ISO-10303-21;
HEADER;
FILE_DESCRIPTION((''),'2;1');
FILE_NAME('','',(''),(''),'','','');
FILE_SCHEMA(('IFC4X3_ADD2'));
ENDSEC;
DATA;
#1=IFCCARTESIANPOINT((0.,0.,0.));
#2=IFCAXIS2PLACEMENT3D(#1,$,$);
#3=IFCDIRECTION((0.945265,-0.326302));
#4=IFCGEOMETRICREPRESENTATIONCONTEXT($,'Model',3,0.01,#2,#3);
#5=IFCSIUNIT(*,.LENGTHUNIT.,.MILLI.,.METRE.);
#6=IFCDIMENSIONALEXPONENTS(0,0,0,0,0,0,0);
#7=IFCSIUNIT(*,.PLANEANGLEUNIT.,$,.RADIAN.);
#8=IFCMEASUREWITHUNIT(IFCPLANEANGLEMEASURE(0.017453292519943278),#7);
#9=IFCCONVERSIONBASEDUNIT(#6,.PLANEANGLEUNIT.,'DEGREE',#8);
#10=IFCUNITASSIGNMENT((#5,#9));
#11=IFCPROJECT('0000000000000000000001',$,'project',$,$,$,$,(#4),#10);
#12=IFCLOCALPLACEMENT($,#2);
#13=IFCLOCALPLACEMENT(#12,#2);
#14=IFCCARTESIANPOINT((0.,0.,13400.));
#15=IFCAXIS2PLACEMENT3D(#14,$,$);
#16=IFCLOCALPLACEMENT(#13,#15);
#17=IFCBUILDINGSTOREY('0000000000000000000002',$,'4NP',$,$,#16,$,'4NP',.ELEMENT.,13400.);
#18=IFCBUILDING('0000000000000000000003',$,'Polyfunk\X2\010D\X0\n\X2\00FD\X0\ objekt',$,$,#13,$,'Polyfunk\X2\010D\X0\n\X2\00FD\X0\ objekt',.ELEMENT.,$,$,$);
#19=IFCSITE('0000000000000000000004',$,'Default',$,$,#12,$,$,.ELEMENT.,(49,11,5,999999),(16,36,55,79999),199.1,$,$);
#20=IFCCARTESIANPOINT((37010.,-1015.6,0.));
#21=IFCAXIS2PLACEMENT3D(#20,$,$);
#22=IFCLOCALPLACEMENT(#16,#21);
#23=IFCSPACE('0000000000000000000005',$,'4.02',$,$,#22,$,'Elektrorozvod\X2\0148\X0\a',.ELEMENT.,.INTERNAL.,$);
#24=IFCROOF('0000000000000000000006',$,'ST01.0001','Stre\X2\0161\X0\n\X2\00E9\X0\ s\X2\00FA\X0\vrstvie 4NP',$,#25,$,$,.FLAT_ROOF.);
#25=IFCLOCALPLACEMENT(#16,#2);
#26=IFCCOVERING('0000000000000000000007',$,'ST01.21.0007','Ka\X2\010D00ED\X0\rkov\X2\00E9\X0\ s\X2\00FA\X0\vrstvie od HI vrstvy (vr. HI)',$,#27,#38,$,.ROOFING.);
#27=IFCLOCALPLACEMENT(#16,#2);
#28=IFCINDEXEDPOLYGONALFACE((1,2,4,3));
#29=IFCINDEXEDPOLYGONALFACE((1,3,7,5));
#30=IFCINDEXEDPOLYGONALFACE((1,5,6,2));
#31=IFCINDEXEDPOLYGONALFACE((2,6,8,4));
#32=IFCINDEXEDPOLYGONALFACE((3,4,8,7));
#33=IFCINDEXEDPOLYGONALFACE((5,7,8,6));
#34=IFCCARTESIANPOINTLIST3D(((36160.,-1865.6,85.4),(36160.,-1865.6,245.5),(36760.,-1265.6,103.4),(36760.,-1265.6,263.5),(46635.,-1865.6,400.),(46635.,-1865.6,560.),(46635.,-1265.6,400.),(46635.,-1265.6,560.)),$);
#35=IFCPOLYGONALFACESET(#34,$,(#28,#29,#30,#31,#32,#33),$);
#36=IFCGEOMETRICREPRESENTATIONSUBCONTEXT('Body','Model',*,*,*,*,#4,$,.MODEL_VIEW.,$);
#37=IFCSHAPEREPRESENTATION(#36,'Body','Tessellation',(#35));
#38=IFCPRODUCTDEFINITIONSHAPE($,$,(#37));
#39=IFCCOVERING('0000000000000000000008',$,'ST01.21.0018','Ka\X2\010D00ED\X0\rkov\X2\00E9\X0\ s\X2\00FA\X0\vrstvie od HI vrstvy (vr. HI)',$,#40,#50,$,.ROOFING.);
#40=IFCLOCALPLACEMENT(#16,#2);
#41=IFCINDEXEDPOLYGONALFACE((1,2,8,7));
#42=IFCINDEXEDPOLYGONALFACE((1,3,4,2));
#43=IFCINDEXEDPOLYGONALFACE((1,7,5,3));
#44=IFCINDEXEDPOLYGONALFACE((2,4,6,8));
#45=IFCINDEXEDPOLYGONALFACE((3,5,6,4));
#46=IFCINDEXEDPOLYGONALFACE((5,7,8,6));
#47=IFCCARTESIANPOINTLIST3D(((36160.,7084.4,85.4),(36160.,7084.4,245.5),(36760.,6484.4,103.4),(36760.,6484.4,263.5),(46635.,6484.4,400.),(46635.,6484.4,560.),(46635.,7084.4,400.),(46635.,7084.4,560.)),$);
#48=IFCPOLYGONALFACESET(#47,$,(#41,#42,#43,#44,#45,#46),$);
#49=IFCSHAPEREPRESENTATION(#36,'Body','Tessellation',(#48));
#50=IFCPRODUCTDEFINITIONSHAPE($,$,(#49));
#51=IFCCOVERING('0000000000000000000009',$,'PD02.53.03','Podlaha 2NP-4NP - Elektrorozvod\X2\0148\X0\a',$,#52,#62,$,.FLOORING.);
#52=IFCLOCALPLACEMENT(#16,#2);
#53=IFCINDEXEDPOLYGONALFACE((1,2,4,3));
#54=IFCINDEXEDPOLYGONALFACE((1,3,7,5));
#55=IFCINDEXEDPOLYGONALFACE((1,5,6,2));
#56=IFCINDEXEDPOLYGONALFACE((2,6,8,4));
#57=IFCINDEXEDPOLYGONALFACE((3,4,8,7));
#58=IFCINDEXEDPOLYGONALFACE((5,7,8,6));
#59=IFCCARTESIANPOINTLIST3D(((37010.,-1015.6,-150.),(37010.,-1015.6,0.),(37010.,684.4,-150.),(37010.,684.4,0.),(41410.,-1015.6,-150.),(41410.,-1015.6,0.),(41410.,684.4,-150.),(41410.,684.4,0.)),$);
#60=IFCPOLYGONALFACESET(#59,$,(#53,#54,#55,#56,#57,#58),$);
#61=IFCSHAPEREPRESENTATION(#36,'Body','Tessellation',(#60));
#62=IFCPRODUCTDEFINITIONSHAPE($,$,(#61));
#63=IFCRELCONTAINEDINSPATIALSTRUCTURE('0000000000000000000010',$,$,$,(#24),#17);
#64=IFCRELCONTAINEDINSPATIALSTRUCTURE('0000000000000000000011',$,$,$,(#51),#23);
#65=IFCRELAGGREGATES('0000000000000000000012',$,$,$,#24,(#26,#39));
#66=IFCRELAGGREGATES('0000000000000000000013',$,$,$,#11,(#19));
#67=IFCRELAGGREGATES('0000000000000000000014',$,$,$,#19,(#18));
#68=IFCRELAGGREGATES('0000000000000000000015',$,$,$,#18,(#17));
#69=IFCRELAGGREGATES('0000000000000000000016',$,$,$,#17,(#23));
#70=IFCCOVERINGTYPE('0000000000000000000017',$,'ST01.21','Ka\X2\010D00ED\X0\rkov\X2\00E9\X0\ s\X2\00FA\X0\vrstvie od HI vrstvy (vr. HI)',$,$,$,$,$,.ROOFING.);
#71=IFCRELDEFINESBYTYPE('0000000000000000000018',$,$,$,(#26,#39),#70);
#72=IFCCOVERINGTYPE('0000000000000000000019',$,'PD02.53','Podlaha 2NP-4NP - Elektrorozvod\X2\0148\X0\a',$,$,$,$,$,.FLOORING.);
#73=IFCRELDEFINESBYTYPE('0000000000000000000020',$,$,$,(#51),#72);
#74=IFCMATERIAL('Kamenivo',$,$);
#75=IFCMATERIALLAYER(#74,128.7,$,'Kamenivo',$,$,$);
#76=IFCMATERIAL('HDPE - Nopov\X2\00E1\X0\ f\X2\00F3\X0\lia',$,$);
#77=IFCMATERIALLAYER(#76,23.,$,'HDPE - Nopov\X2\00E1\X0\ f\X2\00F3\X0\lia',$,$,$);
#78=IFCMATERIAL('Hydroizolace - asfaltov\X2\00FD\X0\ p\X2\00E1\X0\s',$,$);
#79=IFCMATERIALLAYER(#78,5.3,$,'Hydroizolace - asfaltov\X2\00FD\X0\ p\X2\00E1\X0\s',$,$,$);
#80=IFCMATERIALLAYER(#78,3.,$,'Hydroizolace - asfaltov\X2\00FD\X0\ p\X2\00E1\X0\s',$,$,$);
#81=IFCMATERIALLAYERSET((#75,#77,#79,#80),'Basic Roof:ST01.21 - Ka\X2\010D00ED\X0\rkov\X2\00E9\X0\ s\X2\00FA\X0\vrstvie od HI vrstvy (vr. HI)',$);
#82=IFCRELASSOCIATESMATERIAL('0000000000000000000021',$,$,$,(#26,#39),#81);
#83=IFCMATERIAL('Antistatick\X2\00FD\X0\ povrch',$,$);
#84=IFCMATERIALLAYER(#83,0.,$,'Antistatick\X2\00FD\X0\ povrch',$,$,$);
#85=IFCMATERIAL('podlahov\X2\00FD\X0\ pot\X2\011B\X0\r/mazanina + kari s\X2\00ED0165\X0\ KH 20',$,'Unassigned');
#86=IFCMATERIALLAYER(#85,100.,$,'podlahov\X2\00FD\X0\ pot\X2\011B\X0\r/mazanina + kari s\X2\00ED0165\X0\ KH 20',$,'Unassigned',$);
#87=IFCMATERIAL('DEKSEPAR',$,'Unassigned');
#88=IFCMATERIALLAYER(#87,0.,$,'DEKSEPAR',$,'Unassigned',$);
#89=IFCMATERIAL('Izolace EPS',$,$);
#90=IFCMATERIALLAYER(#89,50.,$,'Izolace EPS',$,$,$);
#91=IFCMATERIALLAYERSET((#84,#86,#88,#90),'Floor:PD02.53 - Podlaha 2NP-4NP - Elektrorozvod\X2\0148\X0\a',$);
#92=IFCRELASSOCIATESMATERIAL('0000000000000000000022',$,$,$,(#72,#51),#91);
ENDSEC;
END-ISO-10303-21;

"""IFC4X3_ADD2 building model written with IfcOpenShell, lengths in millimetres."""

from ifc_helpers import new_model, entity, si_unit, converted_unit, direction, frame, frame_2d, origin, place, context, subcontext, project, spatial, polyline, rectangle, outline, extrude, material, layer, layer_set, layer_usage, type_object, element, aggregate, save


model = new_model("IFC4X3_ADD2")

# Units and contexts
model_context = context("Model", 3, precision=0.01, world=origin(), true_north=direction((0.945265, -0.326302)))
body_context = subcontext(model_context, "Body", "Model", "MODEL_VIEW")
ifc_project = project(units=[si_unit("LENGTHUNIT", "METRE", prefix="MILLI"), converted_unit("PLANEANGLEUNIT", "DEGREE", entity("IfcPlaneAngleMeasure", 0.017453292519943278), si_unit("PLANEANGLEUNIT", "RADIAN"), dimensions=[0, 0, 0, 0, 0, 0, 0])], contexts=[model_context])

# Site, building, storey
site_placement = place(None, origin())
site = spatial("IfcSite", under=ifc_project, at=site_placement, Name="Default", CompositionType="ELEMENT", RefLatitude=(49, 11, 5, 999999), RefLongitude=(16, 36, 55, 79999), RefElevation=199.1)
building_placement = place(site_placement, origin())
building = spatial("IfcBuilding", under=site, at=building_placement, Name="Polyfunkčný objekt", LongName="Polyfunkčný objekt", CompositionType="ELEMENT")
storey_placement = place(building_placement, frame((0.0, 0.0, 13400.0)))
storey = spatial("IfcBuildingStorey", under=building, at=storey_placement, Name="4NP", LongName="4NP", CompositionType="ELEMENT", Elevation=13400.0)

# Roof, coverings
roof = element("IfcRoof", 1, inside=storey, Name="ST01.0001", Description="Strešné súvrstvie 4NP", PredefinedType="FLAT_ROOF")
ifc_material_1 = material(Name="Izolace EPS")
ifc_material_2 = material(Name="Hydroizolace - asfaltový pás")
ifc_material_3 = material(Name="HDPE - Nopová fólia")
ifc_material_4 = material(Name="Kamenivo")
ifc_layer_1 = layer(ifc_material_4, 128.7, Name="Kamenivo")
ifc_layer_2 = layer(ifc_material_3, 23.0, Name="HDPE - Nopová fólia")
ifc_layer_3 = layer(ifc_material_2, 5.3, Name="Hydroizolace - asfaltový pás")
ifc_layer_4 = layer(ifc_material_2, 3.0, Name="Hydroizolace - asfaltový pás")
ifc_layer_set_1 = layer_set([ifc_layer_1, ifc_layer_2, ifc_layer_3, ifc_layer_4], Name="Basic Roof:ST01.21 - Kačírkové súvrstvie od HI vrstvy (vr. HI)")
covering_type_1 = type_object("IfcCoveringType", Name="ST01.21", Description="Kačírkové súvrstvie od HI vrstvy (vr. HI)", PredefinedType="ROOFING")
placement_1 = place(storey_placement, frame((36160.0, -1865.6, 85.4)))
covering_1_placement = place(placement_1, origin())
covering_1 = element("IfcCovering", 2, at=covering_1_placement, type_object=covering_type_1, material=ifc_layer_set_1, Name="ST01.21.0007", Description="Kačírkové súvrstvie od HI vrstvy (vr. HI)", PredefinedType="ROOFING", context=body_context, shape_type="SweptSolid", body=[
    extrude(outline(polyline([(-5239.9, -300.0), (5239.9, -300.0), (5239.9, 300.0), (-4639.6, 300.0), (-5239.9, -300.0)])), frame((5237.5, 300.0, 157.3), z_axis=(-0.030015, 0.0, 0.999549), x_axis=(0.999549, 0.0, 0.030015)), (0.030015, 0.0, 0.999549), 160.1),
])
placement_2 = place(storey_placement, frame((36160.0, 6484.4, 85.4)))
covering_2_placement = place(placement_2, origin())
covering_2 = element("IfcCovering", 3, at=covering_2_placement, type_object=covering_type_1, material=ifc_layer_set_1, Name="ST01.21.0018", Description="Kačírkové súvrstvie od HI vrstvy (vr. HI)", PredefinedType="ROOFING", context=body_context, shape_type="SweptSolid", body=[
    extrude(outline(polyline([(-4639.6, -300.0), (5239.9, -300.0), (5239.9, 300.0), (-5239.9, 300.0), (-4639.6, -300.0)])), frame((5237.5, 300.0, 157.3), z_axis=(-0.030015, 0.0, 0.999549), x_axis=(0.999549, 0.0, 0.030015)), (0.030015, 0.0, 0.999549), 160.1),
])
aggregate(roof, [covering_1, covering_2])

# Shared definitions
ifc_material_5 = material(Name="podlahový potěr/mazanina + kari síť KH 20", Category="Unassigned")
ifc_material_6 = material(Name="DEKSEPAR", Category="Unassigned")

# Shared definitions
space_1_placement = place(storey_placement, frame((37010.0, -1015.6, 0.0)))
space_1 = spatial("IfcSpace", under=storey, at=space_1_placement, Name="4.02", LongName="Elektrorozvodňa", CompositionType="ELEMENT", PredefinedType="INTERNAL")

# Covering
ifc_material_7 = material(Name="Antistatický povrch")
ifc_layer_5 = layer(ifc_material_7, 0.0, Name="Antistatický povrch")
ifc_layer_6 = layer(ifc_material_5, 100.0, Name="podlahový potěr/mazanina + kari síť KH 20", Category="Unassigned")
ifc_layer_7 = layer(ifc_material_6, 0.0, Name="DEKSEPAR", Category="Unassigned")
ifc_layer_8 = layer(ifc_material_1, 50.0, Name="Izolace EPS")
ifc_layer_set_2 = layer_set([ifc_layer_5, ifc_layer_6, ifc_layer_7, ifc_layer_8], Name="Floor:PD02.53 - Podlaha 2NP-4NP - Elektrorozvodňa")
ifc_layer_usage_1 = layer_usage(ifc_layer_set_2, "AXIS3", "POSITIVE", 0.0)
covering_type_2 = type_object("IfcCoveringType", Name="PD02.53", Description="Podlaha 2NP-4NP - Elektrorozvodňa", PredefinedType="FLOORING", material=ifc_layer_set_2)
covering_3_placement = place(storey_placement, origin())
element("IfcCovering", 4, at=covering_3_placement, inside=space_1, type_object=covering_type_2, material=ifc_layer_usage_1, Name="PD02.53.03", Description="Podlaha 2NP-4NP - Elektrorozvodňa", PredefinedType="FLOORING", context=body_context, shape_type="SweptSolid", body=[
    extrude(rectangle(XDim=1700.0, YDim=4400.0, at=frame_2d((0.0, 0.0), x_axis=(1.0, 0.0))), frame((39210.0, -165.6, 0.0), z_axis=(0.0, 0.0, -1.0), x_axis=(0.0, 1.0, 0.0)), (0.0, 0.0, 1.0), 150.0),
])

save(model, "model.ifc")
